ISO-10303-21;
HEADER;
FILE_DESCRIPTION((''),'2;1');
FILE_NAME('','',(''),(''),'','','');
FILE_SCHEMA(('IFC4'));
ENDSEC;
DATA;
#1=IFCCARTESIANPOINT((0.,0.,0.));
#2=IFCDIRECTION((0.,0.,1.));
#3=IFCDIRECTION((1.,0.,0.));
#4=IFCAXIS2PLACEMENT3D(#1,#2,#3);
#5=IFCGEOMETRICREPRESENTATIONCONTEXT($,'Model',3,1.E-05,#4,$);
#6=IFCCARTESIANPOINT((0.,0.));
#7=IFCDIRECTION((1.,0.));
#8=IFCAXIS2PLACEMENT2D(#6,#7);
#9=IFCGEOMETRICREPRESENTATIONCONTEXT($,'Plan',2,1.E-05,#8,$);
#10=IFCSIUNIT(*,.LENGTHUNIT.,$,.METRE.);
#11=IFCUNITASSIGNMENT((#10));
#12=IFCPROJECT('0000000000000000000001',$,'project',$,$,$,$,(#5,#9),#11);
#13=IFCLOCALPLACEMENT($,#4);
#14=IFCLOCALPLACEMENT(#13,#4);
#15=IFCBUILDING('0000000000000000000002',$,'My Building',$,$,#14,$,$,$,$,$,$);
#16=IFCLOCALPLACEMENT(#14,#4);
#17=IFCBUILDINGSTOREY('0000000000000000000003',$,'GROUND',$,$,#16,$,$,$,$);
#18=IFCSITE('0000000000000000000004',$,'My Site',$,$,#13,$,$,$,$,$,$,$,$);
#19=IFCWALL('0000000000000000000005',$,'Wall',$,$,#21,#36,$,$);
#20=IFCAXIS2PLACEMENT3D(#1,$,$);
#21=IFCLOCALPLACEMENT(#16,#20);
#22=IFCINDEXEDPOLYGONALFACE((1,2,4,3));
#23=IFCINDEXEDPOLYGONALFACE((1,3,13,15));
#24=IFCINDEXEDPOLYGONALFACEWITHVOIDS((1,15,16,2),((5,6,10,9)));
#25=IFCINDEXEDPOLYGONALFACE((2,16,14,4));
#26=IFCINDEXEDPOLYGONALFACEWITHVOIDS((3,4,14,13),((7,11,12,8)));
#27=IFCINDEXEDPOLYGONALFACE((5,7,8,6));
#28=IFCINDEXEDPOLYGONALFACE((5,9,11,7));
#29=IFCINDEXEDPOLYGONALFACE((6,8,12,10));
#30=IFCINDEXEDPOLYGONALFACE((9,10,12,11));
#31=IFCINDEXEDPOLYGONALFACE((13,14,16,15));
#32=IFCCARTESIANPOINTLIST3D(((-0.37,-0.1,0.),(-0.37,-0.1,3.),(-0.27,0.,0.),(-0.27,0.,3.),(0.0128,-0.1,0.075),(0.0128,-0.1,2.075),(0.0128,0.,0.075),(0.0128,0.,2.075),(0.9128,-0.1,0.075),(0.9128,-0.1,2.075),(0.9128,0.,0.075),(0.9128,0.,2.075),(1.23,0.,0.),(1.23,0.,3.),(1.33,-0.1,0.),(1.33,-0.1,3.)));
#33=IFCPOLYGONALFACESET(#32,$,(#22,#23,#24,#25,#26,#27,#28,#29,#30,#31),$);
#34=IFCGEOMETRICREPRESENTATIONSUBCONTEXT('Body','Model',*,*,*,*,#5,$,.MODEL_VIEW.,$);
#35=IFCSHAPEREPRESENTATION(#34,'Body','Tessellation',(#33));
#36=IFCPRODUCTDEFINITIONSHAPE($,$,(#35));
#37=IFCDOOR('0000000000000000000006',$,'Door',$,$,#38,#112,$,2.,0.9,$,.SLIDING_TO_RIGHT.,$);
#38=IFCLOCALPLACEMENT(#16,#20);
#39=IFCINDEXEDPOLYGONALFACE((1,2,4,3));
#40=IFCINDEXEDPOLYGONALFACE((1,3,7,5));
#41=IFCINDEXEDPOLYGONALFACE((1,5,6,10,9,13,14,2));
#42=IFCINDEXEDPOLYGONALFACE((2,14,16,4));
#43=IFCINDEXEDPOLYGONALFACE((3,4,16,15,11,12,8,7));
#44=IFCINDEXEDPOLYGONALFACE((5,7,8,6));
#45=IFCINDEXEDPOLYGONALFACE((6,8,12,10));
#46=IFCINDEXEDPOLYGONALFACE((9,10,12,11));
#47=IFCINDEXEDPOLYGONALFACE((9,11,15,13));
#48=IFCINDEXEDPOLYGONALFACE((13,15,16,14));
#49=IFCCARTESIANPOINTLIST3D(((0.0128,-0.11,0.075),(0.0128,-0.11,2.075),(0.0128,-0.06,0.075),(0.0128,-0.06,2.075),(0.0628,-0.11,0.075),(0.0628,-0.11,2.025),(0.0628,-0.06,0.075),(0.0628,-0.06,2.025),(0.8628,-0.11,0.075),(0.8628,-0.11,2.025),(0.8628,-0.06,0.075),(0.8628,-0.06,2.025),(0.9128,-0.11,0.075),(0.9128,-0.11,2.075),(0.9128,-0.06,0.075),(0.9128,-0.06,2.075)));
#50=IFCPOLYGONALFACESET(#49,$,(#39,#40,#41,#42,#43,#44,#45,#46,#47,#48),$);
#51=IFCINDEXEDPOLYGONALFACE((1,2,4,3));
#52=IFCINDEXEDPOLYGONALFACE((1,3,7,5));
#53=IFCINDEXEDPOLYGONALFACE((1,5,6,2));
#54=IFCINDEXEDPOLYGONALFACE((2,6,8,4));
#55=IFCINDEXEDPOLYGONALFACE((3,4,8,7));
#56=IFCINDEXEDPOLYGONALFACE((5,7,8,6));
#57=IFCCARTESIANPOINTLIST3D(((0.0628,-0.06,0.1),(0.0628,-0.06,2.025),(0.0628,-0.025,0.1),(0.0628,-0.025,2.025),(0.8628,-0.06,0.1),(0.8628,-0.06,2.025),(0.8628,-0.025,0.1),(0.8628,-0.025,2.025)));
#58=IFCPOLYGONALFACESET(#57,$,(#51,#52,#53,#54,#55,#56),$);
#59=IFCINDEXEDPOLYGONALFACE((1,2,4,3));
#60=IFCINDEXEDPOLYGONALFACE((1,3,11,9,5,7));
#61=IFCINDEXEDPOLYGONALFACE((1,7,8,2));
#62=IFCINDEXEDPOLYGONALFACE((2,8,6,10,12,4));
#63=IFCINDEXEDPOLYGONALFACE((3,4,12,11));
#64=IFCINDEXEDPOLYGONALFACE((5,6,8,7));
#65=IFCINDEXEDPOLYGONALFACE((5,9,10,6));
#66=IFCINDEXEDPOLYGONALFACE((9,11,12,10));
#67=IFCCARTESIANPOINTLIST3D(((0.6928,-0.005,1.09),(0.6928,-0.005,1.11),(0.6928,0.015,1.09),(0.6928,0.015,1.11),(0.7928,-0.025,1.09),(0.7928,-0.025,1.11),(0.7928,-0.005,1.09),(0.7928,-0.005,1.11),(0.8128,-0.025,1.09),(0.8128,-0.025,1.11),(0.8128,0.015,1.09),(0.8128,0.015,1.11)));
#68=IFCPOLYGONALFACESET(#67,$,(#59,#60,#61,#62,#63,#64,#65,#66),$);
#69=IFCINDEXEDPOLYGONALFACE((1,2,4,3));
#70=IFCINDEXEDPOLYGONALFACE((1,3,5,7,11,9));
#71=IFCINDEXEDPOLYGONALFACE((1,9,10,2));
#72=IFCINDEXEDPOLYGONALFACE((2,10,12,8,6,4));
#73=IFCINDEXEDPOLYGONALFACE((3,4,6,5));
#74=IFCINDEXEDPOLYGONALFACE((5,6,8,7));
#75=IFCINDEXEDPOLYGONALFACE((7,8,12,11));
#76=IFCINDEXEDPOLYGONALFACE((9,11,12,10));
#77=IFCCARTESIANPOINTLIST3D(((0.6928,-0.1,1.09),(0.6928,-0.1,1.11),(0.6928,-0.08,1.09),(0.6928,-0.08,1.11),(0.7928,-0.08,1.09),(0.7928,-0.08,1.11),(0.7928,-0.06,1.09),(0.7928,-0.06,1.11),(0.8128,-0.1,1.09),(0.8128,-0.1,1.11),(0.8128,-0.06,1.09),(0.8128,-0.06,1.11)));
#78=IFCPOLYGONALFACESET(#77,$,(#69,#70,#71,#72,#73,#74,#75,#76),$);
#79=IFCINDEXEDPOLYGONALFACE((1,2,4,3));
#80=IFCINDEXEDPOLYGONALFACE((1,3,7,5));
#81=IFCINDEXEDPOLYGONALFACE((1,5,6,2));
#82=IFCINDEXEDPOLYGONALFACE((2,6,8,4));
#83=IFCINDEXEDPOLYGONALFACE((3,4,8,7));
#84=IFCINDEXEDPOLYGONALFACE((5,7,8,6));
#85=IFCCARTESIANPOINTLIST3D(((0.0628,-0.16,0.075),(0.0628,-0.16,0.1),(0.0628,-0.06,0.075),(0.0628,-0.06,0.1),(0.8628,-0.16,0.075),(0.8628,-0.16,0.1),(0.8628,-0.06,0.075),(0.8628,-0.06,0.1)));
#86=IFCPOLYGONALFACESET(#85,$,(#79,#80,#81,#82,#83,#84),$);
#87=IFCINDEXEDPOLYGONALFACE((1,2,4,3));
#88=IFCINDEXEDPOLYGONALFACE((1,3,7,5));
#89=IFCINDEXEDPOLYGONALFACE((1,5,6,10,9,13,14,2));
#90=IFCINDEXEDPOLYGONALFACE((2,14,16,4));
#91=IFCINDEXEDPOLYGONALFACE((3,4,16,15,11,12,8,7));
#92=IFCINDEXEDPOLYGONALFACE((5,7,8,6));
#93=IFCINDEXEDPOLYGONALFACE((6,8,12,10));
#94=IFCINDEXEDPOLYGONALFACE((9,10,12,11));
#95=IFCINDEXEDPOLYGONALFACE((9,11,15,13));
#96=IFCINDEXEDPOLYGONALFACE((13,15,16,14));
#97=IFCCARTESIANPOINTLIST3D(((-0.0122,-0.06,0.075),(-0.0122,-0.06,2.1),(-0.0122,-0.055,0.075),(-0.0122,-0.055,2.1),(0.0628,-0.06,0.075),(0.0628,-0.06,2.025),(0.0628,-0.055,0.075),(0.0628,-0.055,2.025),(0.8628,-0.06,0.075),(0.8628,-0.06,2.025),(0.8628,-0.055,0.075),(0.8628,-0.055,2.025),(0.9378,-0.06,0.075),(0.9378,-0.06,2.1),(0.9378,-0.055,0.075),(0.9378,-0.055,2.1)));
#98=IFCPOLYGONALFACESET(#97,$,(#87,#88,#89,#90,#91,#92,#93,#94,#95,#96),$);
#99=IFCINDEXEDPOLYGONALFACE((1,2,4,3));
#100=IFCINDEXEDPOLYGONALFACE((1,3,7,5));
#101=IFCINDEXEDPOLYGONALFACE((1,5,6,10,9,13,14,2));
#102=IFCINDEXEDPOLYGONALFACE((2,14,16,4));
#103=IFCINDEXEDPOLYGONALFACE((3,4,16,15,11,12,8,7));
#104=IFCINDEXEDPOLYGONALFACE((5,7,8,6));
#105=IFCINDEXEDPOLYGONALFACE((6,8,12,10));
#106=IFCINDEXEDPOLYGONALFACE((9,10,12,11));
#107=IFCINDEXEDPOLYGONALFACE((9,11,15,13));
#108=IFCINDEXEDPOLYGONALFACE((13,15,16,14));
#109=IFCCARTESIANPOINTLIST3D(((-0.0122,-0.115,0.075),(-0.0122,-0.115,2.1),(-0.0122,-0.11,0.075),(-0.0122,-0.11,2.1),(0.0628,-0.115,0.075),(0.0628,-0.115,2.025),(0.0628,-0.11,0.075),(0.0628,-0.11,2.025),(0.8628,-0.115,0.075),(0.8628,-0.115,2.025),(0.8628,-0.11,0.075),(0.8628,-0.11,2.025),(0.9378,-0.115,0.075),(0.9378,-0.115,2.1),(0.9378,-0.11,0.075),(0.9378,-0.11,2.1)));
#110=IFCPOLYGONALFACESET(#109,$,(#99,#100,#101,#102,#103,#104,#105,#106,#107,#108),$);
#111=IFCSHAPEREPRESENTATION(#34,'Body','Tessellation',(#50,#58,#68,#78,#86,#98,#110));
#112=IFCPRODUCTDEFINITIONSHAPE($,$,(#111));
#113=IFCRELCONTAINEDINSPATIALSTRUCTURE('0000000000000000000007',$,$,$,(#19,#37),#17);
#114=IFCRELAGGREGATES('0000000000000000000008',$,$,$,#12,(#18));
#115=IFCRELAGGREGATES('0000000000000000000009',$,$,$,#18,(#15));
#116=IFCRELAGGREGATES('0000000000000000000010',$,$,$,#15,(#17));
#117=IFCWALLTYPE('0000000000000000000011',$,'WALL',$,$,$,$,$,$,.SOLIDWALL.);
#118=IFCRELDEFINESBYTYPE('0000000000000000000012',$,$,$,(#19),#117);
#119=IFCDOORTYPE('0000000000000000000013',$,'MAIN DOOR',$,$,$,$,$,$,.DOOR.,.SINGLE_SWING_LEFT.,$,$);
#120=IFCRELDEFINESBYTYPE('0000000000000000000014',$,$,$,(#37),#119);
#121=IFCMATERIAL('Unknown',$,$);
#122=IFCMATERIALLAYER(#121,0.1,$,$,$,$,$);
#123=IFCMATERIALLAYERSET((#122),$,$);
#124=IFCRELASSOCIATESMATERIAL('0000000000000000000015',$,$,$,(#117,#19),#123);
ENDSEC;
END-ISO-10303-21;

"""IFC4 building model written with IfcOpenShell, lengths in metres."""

from ifc_helpers import new_model, entity, si_unit, frame, origin_with_axes, origin_2d_with_axis, place, context, subcontext, project, spatial, line, indexed_curve, outline, extrude, shape, source, transform, mapped, material, layer, layer_set, layer_usage, type_object, type_shapes, element, fill, save


model = new_model("IFC4")

# Units and contexts
model_context = context("Model", 3, precision=1e-05, world=origin_with_axes())
plan_context = context("Plan", 2, precision=1e-05, world=origin_2d_with_axis())
body_context_1 = subcontext(model_context, "Body", "Model", "MODEL_VIEW")
body_context_2 = subcontext(plan_context, "Body", "Plan", "PLAN_VIEW")
ifc_project = project(units=[si_unit("LENGTHUNIT", "METRE")], contexts=[model_context, plan_context])

# Site, building, storey
site_placement = place(None, origin_with_axes())
site = spatial("IfcSite", under=ifc_project, at=site_placement, Name="My Site")
building_placement = place(site_placement, origin_with_axes())
building = spatial("IfcBuilding", under=site, at=building_placement, Name="My Building")
storey_placement = place(building_placement, origin_with_axes())
storey = spatial("IfcBuildingStorey", under=building, at=storey_placement, Name="GROUND")

# Shared definitions
ifc_material_1 = material(Name="Unknown")
ifc_layer_1 = layer(ifc_material_1, 0.1)
ifc_layer_set_1 = layer_set([ifc_layer_1])
wall_type = type_object("IfcWallType", Name="WALL", PredefinedType="SOLIDWALL", material=ifc_layer_set_1)

# Wall, opening, door
ifc_layer_usage_1 = layer_usage(ifc_layer_set_1, "AXIS2", "POSITIVE", 0.0)
wall_1_placement = place(storey_placement, frame((1.23, 0.0, 0.0), z_axis=(0.0, 0.0, 1.0), x_axis=(-1.0, 0.0, 0.0)))
wall_1 = element("IfcWall", 1, at=wall_1_placement, inside=storey, type_object=wall_type, material=ifc_layer_usage_1, Name="Wall", context=body_context_1, shape_type="SweptSolid", body=[
    extrude(outline(indexed_curve([(0.0, 0.0), (-0.1, 0.1), (1.6, 0.1), (1.5, 0.0)], segments=[line(1, 2, 3, 4, 1)])), origin_with_axes(), (0.0, 0.0, 1.0), 3.0),
])
shared_shape_1 = source(origin_with_axes(), body_context_1, "Body", "SweptSolid", [
    extrude(outline(indexed_curve([(0.0, 0.0), (0.9, 0.0), (0.9, 2.0), (0.0, 2.0)], segments=[line(1, 2, 3, 4, 1)])), frame((0.0, -0.6, 0.0), z_axis=(0.0, -1.0, 0.0), x_axis=(1.0, 0.0, 0.0)), (0.0, 0.0, -1.0), 1.2),
])
opening_1_placement = place(wall_1_placement, frame((0.3172, 0.06, 0.075), z_axis=(0.0, 0.0, 1.0), x_axis=(1.0, -0.000001, 0.0)))
opening_1 = element("IfcOpeningElement", 2, at=opening_1_placement, cuts=wall_1, PredefinedType="OPENING", context=body_context_1, shape_type="MappedRepresentation", body=[
    mapped(shared_shape_1, transform((0.0, 0.0, 0.0), x_axis=(1.0, 0.0, 0.0), y_axis=(0.0, 1.0, 0.0), z_axis=(0.0, 0.0, 1.0), scale=1.0)),
])
door_type = type_object("IfcDoorType", Name="MAIN DOOR", OperationType="SINGLE_SWING_LEFT", PredefinedType="DOOR")
shared_shape_2 = source(origin_with_axes(), body_context_1, "Body", "SweptSolid", [
    extrude(outline(indexed_curve([(0.0, 0.0), (0.0, 2.0), (0.9, 2.0), (0.9, 0.0), (0.85, 0.0), (0.85, 1.95), (0.05, 1.95), (0.05, 0.0)], segments=[line(1, 2, 3, 4, 5, 6, 7, 8, 1)])), frame((0.0, 0.0, 0.0), z_axis=(0.0, -1.0, 0.0), x_axis=(1.0, 0.0, 0.0)), (0.0, 0.0, -1.0), 0.05),
    extrude(outline(indexed_curve([(0.0, 0.0), (0.8, 0.0), (0.8, 0.035), (0.0, 0.035)], segments=[line(1, 2, 3, 4, 1)])), frame((0.05, -0.035, 0.025), z_axis=(0.0, 0.0, 1.0), x_axis=(1.0, 0.0, 0.0)), (0.0, 0.0, 1.0), 1.925),
    extrude(outline(indexed_curve([(0.0, 0.0), (0.0, -0.04), (0.12, -0.04), (0.12, -0.02), (0.02, -0.02), (0.02, 0.0)], segments=[line(1, 2, 3, 4, 5, 6, 1)])), frame((0.1, -0.035, 1.015), z_axis=(0.0, 0.0, 1.0), x_axis=(1.0, 0.0, 0.0)), (0.0, 0.0, 1.0), 0.02),
    extrude(outline(indexed_curve([(0.0, 0.0), (0.0, 0.04), (0.12, 0.04), (0.12, 0.02), (0.02, 0.02), (0.02, 0.0)], segments=[line(1, 2, 3, 4, 5, 6, 1)])), frame((0.1, 0.0, 1.015), z_axis=(0.0, 0.0, 1.0), x_axis=(1.0, 0.0, 0.0)), (0.0, 0.0, 1.0), 0.02),
    extrude(outline(indexed_curve([(0.0, 0.0), (0.8, 0.0), (0.8, 0.1), (0.0, 0.1)], segments=[line(1, 2, 3, 4, 1)])), frame((0.05, 0.0, 0.0), z_axis=(0.0, 0.0, 1.0), x_axis=(1.0, 0.0, 0.0)), (0.0, 0.0, 1.0), 0.025),
    extrude(outline(indexed_curve([(0.0, 0.0), (0.0, 2.025), (0.95, 2.025), (0.95, 0.0), (0.875, 0.0), (0.875, 1.95), (0.075, 1.95), (0.075, 0.0)], segments=[line(1, 2, 3, 4, 5, 6, 7, 8, 1)])), frame((-0.025, -0.005, 0.0), z_axis=(0.0, -1.0, 0.0), x_axis=(1.0, 0.0, 0.0)), (0.0, 0.0, -1.0), 0.005),
    extrude(outline(indexed_curve([(0.0, 0.0), (0.0, 2.025), (0.95, 2.025), (0.95, 0.0), (0.875, 0.0), (0.875, 1.95), (0.075, 1.95), (0.075, 0.0)], segments=[line(1, 2, 3, 4, 5, 6, 7, 8, 1)])), frame((-0.025, 0.05, 0.0), z_axis=(0.0, -1.0, 0.0), x_axis=(1.0, 0.0, 0.0)), (0.0, 0.0, -1.0), 0.005),
])
shared_shape_3 = source(origin_with_axes(), body_context_2, "Body", "Curve2D", [
    entity("IfcIndexedPolyCurve", entity("IfcCartesianPointList2D", [[0.0, 0.0], [0.05, 0.0], [0.05, 0.05], [0.0, 0.05]]), [entity("IfcLineIndex", [1, 2, 3, 4, 1])]),
    entity("IfcIndexedPolyCurve", entity("IfcCartesianPointList2D", [[0.9, 0.0], [0.85, 0.0], [0.85, 0.05], [0.9, 0.05]]), [entity("IfcLineIndex", [1, 2, 3, 4, 1])]),
    entity("IfcIndexedPolyCurve", entity("IfcCartesianPointList2D", [[1.25, -0.035], [0.45, -0.035], [0.45, 0.0], [1.25, 0.0]]), [entity("IfcLineIndex", [1, 2, 3, 4, 1])]),
])
type_shapes(door_type, [shared_shape_2, shared_shape_3])
door_placement = place(opening_1_placement, frame((0.0, 0.0, 0.0), z_axis=(0.0, 0.0, 1.0), x_axis=(1.0, 0.0, 0.0)))
door = element("IfcDoor", 3, at=door_placement, inside=storey, type_object=door_type, Name="Door", OperationType="SLIDING_TO_RIGHT", OverallHeight=2.0, OverallWidth=0.9, shapes=[
    shape(body_context_1, "Body", "MappedRepresentation", [mapped(shared_shape_2, transform((0.0, 0.0, 0.0), x_axis=(1.0, 0.0, 0.0), y_axis=(0.0, 1.0, 0.0), z_axis=(0.0, 0.0, 1.0), scale=1.0))]),
    shape(body_context_2, "Body", "MappedRepresentation", [mapped(shared_shape_3, transform((0.0, 0.0, 0.0), x_axis=(1.0, 0.0, 0.0), y_axis=(0.0, 1.0, 0.0), z_axis=(0.0, 0.0, 1.0), scale=1.0))]),
])
fill(opening_1, door)

save(model, "model.ifc")
